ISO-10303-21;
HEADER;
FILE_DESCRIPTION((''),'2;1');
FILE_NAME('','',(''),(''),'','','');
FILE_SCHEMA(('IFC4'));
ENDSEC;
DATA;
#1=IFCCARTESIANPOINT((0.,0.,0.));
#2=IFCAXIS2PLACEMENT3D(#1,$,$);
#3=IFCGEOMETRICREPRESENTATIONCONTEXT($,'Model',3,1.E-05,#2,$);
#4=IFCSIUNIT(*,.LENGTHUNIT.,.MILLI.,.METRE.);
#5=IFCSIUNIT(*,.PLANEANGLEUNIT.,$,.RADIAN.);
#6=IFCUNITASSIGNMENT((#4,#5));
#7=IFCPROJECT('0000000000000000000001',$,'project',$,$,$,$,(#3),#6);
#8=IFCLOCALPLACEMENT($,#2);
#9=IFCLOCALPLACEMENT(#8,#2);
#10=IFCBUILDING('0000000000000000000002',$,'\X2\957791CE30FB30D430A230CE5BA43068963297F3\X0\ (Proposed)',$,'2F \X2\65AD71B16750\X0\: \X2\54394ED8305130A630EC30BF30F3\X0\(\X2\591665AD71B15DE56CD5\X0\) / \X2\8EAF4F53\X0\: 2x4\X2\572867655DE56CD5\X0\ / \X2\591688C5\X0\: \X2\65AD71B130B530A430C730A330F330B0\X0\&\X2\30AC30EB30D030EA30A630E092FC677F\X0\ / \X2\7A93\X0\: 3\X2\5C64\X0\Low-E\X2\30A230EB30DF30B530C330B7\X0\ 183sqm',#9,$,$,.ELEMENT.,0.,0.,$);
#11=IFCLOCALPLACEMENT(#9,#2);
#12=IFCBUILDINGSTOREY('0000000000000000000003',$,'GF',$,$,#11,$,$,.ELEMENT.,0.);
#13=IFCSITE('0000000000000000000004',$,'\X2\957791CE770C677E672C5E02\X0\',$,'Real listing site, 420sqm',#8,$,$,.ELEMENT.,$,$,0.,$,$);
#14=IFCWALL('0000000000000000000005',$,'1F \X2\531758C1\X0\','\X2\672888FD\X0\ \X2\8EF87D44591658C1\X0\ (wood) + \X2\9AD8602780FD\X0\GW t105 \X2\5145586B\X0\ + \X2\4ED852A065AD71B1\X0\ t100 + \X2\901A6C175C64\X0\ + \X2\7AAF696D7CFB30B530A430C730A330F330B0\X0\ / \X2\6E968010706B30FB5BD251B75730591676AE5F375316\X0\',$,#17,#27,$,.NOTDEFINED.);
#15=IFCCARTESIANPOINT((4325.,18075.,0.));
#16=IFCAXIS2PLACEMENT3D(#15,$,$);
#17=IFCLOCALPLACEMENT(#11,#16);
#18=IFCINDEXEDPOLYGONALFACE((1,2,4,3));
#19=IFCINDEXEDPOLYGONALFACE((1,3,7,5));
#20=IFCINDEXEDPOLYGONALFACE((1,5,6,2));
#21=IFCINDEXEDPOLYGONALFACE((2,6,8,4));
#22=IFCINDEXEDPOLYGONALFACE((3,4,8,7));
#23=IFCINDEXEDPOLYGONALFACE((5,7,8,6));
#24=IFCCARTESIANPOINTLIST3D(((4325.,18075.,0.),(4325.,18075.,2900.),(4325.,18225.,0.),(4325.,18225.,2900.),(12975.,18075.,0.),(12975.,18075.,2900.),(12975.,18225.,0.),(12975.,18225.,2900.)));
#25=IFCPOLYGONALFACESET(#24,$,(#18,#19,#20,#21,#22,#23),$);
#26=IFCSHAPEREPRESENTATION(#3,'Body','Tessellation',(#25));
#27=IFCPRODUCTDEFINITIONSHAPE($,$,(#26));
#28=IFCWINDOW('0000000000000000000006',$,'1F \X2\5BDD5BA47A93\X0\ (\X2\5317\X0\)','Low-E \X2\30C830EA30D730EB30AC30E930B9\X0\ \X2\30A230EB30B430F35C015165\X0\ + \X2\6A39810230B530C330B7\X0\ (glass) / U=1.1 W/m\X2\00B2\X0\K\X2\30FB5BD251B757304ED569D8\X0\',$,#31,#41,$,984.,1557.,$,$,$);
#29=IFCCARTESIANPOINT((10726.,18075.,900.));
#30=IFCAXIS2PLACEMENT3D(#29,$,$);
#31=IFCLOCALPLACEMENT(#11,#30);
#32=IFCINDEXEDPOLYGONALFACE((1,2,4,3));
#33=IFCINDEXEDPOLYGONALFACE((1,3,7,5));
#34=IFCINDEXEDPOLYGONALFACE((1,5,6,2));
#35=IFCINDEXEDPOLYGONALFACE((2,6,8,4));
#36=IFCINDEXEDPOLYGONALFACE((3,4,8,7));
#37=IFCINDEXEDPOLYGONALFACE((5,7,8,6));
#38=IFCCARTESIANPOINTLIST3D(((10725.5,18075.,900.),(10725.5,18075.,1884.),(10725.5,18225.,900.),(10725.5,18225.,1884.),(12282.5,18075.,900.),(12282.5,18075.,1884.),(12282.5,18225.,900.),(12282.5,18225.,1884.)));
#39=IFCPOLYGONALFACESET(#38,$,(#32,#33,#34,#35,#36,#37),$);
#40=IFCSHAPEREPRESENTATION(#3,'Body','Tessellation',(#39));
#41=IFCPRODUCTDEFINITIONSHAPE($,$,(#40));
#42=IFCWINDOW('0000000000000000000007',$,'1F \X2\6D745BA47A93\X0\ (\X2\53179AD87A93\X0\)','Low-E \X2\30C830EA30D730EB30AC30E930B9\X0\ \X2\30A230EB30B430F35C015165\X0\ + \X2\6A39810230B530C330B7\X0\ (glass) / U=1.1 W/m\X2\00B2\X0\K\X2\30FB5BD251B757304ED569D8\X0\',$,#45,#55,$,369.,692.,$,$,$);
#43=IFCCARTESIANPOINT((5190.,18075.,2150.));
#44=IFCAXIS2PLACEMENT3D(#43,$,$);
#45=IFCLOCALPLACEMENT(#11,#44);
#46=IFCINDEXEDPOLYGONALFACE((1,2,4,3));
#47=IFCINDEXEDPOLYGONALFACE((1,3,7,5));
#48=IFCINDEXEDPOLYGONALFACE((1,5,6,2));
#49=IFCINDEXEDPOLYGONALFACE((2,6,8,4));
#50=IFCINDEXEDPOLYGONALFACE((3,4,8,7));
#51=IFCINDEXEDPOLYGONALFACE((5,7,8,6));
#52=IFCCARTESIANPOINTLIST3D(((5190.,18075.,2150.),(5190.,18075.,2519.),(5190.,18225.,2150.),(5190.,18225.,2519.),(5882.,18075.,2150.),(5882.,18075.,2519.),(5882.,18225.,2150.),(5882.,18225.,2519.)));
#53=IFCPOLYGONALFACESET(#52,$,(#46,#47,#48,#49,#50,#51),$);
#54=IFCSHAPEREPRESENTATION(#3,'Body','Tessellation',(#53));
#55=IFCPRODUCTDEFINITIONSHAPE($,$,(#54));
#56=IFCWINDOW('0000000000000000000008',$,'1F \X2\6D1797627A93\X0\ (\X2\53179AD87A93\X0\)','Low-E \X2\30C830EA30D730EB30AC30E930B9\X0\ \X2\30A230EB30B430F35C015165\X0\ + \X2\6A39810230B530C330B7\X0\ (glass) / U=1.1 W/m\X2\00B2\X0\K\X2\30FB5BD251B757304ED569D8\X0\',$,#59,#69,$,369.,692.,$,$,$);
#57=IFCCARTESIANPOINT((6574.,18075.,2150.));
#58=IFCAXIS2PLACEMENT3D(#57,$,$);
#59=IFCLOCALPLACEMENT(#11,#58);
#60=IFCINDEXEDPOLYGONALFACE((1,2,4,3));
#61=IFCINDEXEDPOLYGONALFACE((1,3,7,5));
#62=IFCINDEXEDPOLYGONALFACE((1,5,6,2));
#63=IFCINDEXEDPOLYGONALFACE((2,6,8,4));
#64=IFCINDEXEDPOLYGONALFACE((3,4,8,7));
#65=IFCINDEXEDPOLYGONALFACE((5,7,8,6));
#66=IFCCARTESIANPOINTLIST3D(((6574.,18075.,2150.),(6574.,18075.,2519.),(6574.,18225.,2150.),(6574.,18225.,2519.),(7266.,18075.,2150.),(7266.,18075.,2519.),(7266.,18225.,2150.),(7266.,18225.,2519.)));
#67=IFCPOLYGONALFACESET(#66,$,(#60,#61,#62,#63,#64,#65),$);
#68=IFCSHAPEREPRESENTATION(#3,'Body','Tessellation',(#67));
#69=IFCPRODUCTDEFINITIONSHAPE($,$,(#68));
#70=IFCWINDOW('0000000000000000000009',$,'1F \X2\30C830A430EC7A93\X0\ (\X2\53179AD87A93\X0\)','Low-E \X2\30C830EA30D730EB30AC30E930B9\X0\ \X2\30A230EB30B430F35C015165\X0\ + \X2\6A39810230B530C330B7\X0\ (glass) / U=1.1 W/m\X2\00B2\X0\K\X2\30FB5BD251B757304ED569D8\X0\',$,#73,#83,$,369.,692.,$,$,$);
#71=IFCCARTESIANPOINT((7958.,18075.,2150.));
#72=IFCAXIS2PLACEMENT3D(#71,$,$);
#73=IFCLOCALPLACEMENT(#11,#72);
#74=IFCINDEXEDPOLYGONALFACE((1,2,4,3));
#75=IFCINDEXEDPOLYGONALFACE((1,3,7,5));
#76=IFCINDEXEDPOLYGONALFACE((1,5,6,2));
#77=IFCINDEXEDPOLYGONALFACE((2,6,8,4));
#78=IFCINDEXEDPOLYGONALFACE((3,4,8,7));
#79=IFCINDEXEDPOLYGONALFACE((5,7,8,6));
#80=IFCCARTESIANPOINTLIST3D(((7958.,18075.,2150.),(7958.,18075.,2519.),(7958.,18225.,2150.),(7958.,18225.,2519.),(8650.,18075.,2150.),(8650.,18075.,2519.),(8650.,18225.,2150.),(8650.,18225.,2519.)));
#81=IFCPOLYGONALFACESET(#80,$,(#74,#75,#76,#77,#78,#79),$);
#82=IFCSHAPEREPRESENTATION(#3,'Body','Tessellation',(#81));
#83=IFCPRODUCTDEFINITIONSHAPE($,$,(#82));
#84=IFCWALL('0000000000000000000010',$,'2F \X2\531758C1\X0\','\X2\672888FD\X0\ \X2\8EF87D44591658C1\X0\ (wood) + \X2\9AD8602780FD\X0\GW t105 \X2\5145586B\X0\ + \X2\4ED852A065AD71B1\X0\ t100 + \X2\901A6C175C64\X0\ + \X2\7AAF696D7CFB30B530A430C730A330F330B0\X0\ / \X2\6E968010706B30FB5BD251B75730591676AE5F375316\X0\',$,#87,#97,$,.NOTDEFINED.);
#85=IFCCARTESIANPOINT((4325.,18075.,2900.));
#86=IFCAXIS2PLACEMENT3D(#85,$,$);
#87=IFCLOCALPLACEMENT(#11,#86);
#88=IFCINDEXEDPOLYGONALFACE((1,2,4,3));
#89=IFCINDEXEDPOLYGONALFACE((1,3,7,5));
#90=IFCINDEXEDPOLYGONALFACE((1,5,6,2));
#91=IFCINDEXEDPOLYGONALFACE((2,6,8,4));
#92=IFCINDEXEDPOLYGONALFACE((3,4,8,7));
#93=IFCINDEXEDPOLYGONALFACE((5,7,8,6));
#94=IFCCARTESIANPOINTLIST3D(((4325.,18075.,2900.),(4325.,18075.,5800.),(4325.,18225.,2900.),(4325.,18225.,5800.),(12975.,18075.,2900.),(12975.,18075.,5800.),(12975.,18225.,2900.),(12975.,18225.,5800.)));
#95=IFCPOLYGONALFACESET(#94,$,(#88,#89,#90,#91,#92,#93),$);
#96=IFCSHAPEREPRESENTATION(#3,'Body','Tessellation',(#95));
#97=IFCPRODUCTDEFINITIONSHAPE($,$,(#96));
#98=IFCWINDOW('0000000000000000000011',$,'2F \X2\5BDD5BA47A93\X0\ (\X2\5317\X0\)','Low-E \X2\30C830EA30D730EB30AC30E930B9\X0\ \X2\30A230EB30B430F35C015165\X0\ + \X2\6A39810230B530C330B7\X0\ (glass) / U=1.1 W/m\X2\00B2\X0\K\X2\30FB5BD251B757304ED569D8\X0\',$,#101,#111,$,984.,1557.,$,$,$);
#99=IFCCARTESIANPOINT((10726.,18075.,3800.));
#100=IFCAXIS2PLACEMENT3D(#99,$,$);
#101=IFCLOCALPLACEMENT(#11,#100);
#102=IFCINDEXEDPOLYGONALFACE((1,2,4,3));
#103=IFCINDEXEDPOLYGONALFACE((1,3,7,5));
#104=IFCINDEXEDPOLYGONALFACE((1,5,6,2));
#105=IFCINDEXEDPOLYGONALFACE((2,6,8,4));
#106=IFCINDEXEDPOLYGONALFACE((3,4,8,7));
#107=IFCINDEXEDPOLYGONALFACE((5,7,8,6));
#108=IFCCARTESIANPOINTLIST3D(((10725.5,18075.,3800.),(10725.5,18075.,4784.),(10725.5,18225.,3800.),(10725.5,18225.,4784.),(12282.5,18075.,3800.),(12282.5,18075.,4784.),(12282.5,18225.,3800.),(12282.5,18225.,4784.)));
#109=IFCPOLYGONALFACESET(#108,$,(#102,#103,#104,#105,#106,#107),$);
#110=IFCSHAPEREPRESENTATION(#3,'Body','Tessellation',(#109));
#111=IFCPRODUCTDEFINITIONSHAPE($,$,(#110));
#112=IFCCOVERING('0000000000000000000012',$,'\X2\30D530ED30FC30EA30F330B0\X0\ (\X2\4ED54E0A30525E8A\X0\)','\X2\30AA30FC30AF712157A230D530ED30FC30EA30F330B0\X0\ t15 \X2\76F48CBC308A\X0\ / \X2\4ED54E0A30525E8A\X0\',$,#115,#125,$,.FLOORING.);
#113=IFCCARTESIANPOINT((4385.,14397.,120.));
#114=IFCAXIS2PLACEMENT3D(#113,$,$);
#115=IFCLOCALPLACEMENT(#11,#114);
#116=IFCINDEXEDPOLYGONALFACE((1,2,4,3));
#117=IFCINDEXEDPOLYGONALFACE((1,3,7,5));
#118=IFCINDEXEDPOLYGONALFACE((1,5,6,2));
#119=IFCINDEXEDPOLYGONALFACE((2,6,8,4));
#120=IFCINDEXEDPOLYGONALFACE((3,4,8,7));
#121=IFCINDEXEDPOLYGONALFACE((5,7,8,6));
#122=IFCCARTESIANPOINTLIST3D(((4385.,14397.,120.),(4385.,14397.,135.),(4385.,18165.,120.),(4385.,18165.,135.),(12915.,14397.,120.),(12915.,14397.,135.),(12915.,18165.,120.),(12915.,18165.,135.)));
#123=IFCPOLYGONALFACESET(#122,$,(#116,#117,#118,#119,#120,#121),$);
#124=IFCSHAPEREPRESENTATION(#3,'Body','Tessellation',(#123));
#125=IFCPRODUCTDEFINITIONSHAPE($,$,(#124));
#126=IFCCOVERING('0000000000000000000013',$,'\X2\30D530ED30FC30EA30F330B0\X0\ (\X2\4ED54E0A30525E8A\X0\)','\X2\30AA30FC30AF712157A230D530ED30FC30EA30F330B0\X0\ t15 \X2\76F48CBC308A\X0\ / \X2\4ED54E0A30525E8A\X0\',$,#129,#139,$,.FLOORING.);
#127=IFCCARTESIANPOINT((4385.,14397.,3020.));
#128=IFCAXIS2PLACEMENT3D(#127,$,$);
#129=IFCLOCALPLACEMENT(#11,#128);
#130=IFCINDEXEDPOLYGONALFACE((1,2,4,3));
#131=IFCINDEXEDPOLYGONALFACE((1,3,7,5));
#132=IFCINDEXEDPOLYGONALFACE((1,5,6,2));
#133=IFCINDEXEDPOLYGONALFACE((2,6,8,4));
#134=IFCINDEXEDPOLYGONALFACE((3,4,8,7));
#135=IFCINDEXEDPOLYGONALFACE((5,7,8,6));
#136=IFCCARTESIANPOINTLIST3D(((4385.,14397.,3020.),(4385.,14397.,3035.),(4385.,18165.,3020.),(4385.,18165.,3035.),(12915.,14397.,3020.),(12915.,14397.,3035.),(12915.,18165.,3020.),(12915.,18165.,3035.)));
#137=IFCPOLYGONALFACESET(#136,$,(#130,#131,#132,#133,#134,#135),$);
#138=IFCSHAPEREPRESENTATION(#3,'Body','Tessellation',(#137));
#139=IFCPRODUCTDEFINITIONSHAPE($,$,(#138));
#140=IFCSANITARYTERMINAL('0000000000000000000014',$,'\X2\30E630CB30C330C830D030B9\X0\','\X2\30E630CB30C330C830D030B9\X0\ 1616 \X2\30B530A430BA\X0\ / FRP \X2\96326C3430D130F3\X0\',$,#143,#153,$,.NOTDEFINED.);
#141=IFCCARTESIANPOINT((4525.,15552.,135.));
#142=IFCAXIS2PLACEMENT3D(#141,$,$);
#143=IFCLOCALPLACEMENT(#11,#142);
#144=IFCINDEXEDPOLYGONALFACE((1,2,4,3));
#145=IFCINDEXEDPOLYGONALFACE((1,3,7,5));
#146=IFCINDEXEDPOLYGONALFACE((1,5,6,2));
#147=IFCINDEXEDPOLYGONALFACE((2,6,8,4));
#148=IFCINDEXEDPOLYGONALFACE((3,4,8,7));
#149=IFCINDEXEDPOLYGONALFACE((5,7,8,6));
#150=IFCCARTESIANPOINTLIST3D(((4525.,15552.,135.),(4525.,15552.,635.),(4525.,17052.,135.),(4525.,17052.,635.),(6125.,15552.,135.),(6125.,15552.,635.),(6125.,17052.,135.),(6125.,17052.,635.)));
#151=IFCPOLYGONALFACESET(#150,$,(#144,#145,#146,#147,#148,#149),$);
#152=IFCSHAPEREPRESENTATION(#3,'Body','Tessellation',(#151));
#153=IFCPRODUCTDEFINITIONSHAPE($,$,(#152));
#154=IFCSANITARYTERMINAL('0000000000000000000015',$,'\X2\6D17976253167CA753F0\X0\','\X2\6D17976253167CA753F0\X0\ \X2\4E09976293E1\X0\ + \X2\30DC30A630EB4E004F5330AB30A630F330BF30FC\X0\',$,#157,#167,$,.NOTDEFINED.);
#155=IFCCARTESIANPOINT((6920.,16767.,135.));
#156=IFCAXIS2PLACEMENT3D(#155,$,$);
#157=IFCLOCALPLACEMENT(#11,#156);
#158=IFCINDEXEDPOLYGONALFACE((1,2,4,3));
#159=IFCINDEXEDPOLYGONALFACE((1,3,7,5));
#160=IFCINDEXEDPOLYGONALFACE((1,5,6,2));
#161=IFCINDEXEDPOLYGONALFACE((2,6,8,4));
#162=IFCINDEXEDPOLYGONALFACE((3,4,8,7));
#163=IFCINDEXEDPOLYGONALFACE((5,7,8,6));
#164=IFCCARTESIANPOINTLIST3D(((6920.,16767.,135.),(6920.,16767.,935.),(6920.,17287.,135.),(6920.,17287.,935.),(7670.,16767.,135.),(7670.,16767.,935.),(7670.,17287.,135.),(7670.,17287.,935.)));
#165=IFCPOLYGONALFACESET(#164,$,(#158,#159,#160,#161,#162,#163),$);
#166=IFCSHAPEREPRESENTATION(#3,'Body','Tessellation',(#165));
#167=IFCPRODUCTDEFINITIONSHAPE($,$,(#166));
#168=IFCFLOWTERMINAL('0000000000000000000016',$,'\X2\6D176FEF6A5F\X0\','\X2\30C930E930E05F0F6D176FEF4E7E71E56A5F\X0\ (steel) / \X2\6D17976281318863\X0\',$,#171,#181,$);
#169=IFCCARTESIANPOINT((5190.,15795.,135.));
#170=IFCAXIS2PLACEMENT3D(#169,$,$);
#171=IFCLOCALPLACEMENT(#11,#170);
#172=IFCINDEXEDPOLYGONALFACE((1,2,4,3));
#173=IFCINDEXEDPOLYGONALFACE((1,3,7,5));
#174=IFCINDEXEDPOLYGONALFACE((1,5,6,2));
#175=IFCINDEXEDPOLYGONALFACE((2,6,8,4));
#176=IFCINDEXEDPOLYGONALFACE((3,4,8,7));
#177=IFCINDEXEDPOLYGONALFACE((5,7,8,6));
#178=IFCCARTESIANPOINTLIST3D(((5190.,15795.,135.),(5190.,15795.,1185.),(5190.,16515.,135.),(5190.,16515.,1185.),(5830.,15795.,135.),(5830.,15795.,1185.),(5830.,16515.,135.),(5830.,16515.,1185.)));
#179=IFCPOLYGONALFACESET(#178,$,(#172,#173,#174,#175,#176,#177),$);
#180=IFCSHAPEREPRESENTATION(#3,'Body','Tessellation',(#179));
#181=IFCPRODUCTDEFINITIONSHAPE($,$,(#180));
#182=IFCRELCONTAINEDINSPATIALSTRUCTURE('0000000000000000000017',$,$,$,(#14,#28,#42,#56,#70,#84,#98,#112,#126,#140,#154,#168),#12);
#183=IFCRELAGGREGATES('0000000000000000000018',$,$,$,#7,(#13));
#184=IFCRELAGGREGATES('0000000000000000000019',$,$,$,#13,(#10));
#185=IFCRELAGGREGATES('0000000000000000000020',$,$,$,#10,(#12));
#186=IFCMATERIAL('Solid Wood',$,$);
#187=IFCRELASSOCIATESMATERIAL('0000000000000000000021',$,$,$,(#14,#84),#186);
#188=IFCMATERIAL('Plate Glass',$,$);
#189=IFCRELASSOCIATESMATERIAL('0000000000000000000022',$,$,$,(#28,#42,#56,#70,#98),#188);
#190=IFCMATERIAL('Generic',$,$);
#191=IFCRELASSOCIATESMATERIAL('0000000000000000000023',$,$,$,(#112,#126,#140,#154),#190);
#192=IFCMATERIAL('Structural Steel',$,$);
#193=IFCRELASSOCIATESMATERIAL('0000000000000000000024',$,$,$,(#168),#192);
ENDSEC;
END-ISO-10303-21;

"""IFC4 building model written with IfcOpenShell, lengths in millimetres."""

from ifc_helpers import new_model, si_unit, frame, frame_2d, origin, place, context, project, spatial, rectangle, extrude, material, element, fill, save


model = new_model("IFC4")

# Units and contexts
model_context = context("Model", 3, precision=1e-05, world=origin())
ifc_project = project(units=[si_unit("LENGTHUNIT", "METRE", prefix="MILLI"), si_unit("PLANEANGLEUNIT", "RADIAN")], contexts=[model_context])

# Site, building, storey
site_placement = place(None, origin())
site = spatial("IfcSite", under=ifc_project, at=site_placement, Name="長野県松本市", ObjectType="Real listing site, 420sqm", CompositionType="ELEMENT", RefElevation=0.0)
building_placement = place(site_placement, origin())
building = spatial("IfcBuilding", under=site, at=building_placement, Name="長野・ピアノ室と防音 (Proposed)", ObjectType="2F 断熱材: 吹付けウレタン(外断熱工法) / 躯体: 2x4在来工法 / 外装: 断熱サイディング&ガルバリウム鋼板 / 窓: 3層Low-Eアルミサッシ 183sqm", CompositionType="ELEMENT", ElevationOfRefHeight=0.0, ElevationOfTerrain=0.0)
storey_placement = place(building_placement, origin())
storey = spatial("IfcBuildingStorey", under=building, at=storey_placement, Name="GF", CompositionType="ELEMENT", Elevation=0.0)

# Shared definitions
ifc_material_1 = material(Name="Solid Wood")

# Wall, openings, windows
wall_1_placement = place(storey_placement, frame((4325.0, 18075.0, 0.0)))
wall_1 = element("IfcWall", 1, at=wall_1_placement, inside=storey, material=ifc_material_1, Name="1F 北壁", Description="木製 軸組外壁 (wood) + 高性能GW t105 充填 + 付加断熱 t100 + 通気層 + 窯業系サイディング / 準耐火・寒冷地外皮強化", PredefinedType="NOTDEFINED", context=model_context, shape_type="SweptSolid", body=[
    extrude(rectangle(XDim=8650.0, YDim=150.0, at=frame_2d((4325.0, 75.0))), frame((4325.0, 18075.0, 0.0)), (0.0, 0.0, 1.0), 2900.0),
])
opening_1_placement = place(storey_placement, frame((10726.0, 18075.0, 900.0)))
opening_1 = element("IfcOpeningElement", 2, at=opening_1_placement, cuts=wall_1, PredefinedType="NOTDEFINED", context=model_context, shape_type="SweptSolid", body=[
    extrude(rectangle(XDim=1557.0, YDim=150.0, at=frame_2d((778.0, 75.0))), frame((10726.0, 18075.0, 900.0)), (0.0, 0.0, 1.0), 984.0),
])
opening_2_placement = place(storey_placement, frame((5190.0, 18075.0, 2150.0)))
opening_2 = element("IfcOpeningElement", 3, at=opening_2_placement, cuts=wall_1, PredefinedType="NOTDEFINED", context=model_context, shape_type="SweptSolid", body=[
    extrude(rectangle(XDim=692.0, YDim=150.0, at=frame_2d((346.0, 75.0))), frame((5190.0, 18075.0, 2150.0)), (0.0, 0.0, 1.0), 369.0),
])
opening_3_placement = place(storey_placement, frame((6574.0, 18075.0, 2150.0)))
opening_3 = element("IfcOpeningElement", 4, at=opening_3_placement, cuts=wall_1, PredefinedType="NOTDEFINED", context=model_context, shape_type="SweptSolid", body=[
    extrude(rectangle(XDim=692.0, YDim=150.0, at=frame_2d((346.0, 75.0))), frame((6574.0, 18075.0, 2150.0)), (0.0, 0.0, 1.0), 369.0),
])
opening_4_placement = place(storey_placement, frame((7958.0, 18075.0, 2150.0)))
opening_4 = element("IfcOpeningElement", 5, at=opening_4_placement, cuts=wall_1, PredefinedType="NOTDEFINED", context=model_context, shape_type="SweptSolid", body=[
    extrude(rectangle(XDim=692.0, YDim=150.0, at=frame_2d((346.0, 75.0))), frame((7958.0, 18075.0, 2150.0)), (0.0, 0.0, 1.0), 369.0),
])
ifc_material_2 = material(Name="Plate Glass")
window_1_placement = place(storey_placement, frame((10726.0, 18075.0, 900.0)))
window_1 = element("IfcWindow", 6, at=window_1_placement, inside=storey, material=ifc_material_2, Name="1F 寝室窓 (北)", Description="Low-E トリプルガラス アルゴン封入 + 樹脂サッシ (glass) / U=1.1 W/m²K・寒冷地仕様", OverallHeight=984.0, OverallWidth=1557.0, context=model_context, shape_type="SweptSolid", body=[
    extrude(rectangle(XDim=1557.0, YDim=150.0, at=frame_2d((778.0, 75.0))), frame((10726.0, 18075.0, 900.0)), (0.0, 0.0, 1.0), 984.0),
])
fill(opening_1, window_1)
window_2_placement = place(storey_placement, frame((5190.0, 18075.0, 2150.0)))
window_2 = element("IfcWindow", 7, at=window_2_placement, inside=storey, material=ifc_material_2, Name="1F 浴室窓 (北高窓)", Description="Low-E トリプルガラス アルゴン封入 + 樹脂サッシ (glass) / U=1.1 W/m²K・寒冷地仕様", OverallHeight=369.0, OverallWidth=692.0, context=model_context, shape_type="SweptSolid", body=[
    extrude(rectangle(XDim=692.0, YDim=150.0, at=frame_2d((346.0, 75.0))), frame((5190.0, 18075.0, 2150.0)), (0.0, 0.0, 1.0), 369.0),
])
fill(opening_2, window_2)
window_3_placement = place(storey_placement, frame((6574.0, 18075.0, 2150.0)))
window_3 = element("IfcWindow", 8, at=window_3_placement, inside=storey, material=ifc_material_2, Name="1F 洗面窓 (北高窓)", Description="Low-E トリプルガラス アルゴン封入 + 樹脂サッシ (glass) / U=1.1 W/m²K・寒冷地仕様", OverallHeight=369.0, OverallWidth=692.0, context=model_context, shape_type="SweptSolid", body=[
    extrude(rectangle(XDim=692.0, YDim=150.0, at=frame_2d((346.0, 75.0))), frame((6574.0, 18075.0, 2150.0)), (0.0, 0.0, 1.0), 369.0),
])
fill(opening_3, window_3)
window_4_placement = place(storey_placement, frame((7958.0, 18075.0, 2150.0)))
window_4 = element("IfcWindow", 9, at=window_4_placement, inside=storey, material=ifc_material_2, Name="1F トイレ窓 (北高窓)", Description="Low-E トリプルガラス アルゴン封入 + 樹脂サッシ (glass) / U=1.1 W/m²K・寒冷地仕様", OverallHeight=369.0, OverallWidth=692.0, context=model_context, shape_type="SweptSolid", body=[
    extrude(rectangle(XDim=692.0, YDim=150.0, at=frame_2d((346.0, 75.0))), frame((7958.0, 18075.0, 2150.0)), (0.0, 0.0, 1.0), 369.0),
])
fill(opening_4, window_4)

# Wall, opening, window
wall_2_placement = place(storey_placement, frame((4325.0, 18075.0, 2900.0)))
wall_2 = element("IfcWall", 10, at=wall_2_placement, inside=storey, material=ifc_material_1, Name="2F 北壁", Description="木製 軸組外壁 (wood) + 高性能GW t105 充填 + 付加断熱 t100 + 通気層 + 窯業系サイディング / 準耐火・寒冷地外皮強化", PredefinedType="NOTDEFINED", context=model_context, shape_type="SweptSolid", body=[
    extrude(rectangle(XDim=8650.0, YDim=150.0, at=frame_2d((4325.0, 75.0))), frame((4325.0, 18075.0, 2900.0)), (0.0, 0.0, 1.0), 2900.0),
])
opening_5_placement = place(storey_placement, frame((10726.0, 18075.0, 3800.0)))
opening_5 = element("IfcOpeningElement", 11, at=opening_5_placement, cuts=wall_2, PredefinedType="NOTDEFINED", context=model_context, shape_type="SweptSolid", body=[
    extrude(rectangle(XDim=1557.0, YDim=150.0, at=frame_2d((778.0, 75.0))), frame((10726.0, 18075.0, 3800.0)), (0.0, 0.0, 1.0), 984.0),
])
window_5_placement = place(storey_placement, frame((10726.0, 18075.0, 3800.0)))
window_5 = element("IfcWindow", 12, at=window_5_placement, inside=storey, material=ifc_material_2, Name="2F 寝室窓 (北)", Description="Low-E トリプルガラス アルゴン封入 + 樹脂サッシ (glass) / U=1.1 W/m²K・寒冷地仕様", OverallHeight=984.0, OverallWidth=1557.0, context=model_context, shape_type="SweptSolid", body=[
    extrude(rectangle(XDim=1557.0, YDim=150.0, at=frame_2d((778.0, 75.0))), frame((10726.0, 18075.0, 3800.0)), (0.0, 0.0, 1.0), 984.0),
])
fill(opening_5, window_5)

# Coverings
ifc_material_3 = material(Name="Generic")
covering_1_placement = place(storey_placement, frame((4385.0, 14397.0, 120.0)))
element("IfcCovering", 13, at=covering_1_placement, inside=storey, material=ifc_material_3, Name="フローリング (仕上げ床)", Description="オーク無垢フローリング t15 直貼り / 仕上げ床", PredefinedType="FLOORING", context=model_context, shape_type="SweptSolid", body=[
    extrude(rectangle(XDim=8530.0, YDim=3768.0, at=frame_2d((4265.0, 1884.0))), frame((4385.0, 14397.0, 120.0)), (0.0, 0.0, 1.0), 15.0),
])
covering_2_placement = place(storey_placement, frame((4385.0, 14397.0, 3020.0)))
element("IfcCovering", 14, at=covering_2_placement, inside=storey, material=ifc_material_3, Name="フローリング (仕上げ床)", Description="オーク無垢フローリング t15 直貼り / 仕上げ床", PredefinedType="FLOORING", context=model_context, shape_type="SweptSolid", body=[
    extrude(rectangle(XDim=8530.0, YDim=3768.0, at=frame_2d((4265.0, 1884.0))), frame((4385.0, 14397.0, 3020.0)), (0.0, 0.0, 1.0), 15.0),
])

# Sanitary terminals
sanitary_terminal_1_placement = place(storey_placement, frame((4525.0, 15552.0, 135.0)))
element("IfcSanitaryTerminal", 15, at=sanitary_terminal_1_placement, inside=storey, material=ifc_material_3, Name="ユニットバス", Description="ユニットバス 1616 サイズ / FRP 防水パン", PredefinedType="NOTDEFINED", context=model_context, shape_type="SweptSolid", body=[
    extrude(rectangle(XDim=1600.0, YDim=1500.0, at=frame_2d((800.0, 750.0))), frame((4525.0, 15552.0, 135.0)), (0.0, 0.0, 1.0), 500.0),
])
sanitary_terminal_2_placement = place(storey_placement, frame((6920.0, 16767.0, 135.0)))
element("IfcSanitaryTerminal", 16, at=sanitary_terminal_2_placement, inside=storey, material=ifc_material_3, Name="洗面化粧台", Description="洗面化粧台 三面鏡 + ボウル一体カウンター", PredefinedType="NOTDEFINED", context=model_context, shape_type="SweptSolid", body=[
    extrude(rectangle(XDim=750.0, YDim=520.0, at=frame_2d((375.0, 260.0))), frame((6920.0, 16767.0, 135.0)), (0.0, 0.0, 1.0), 800.0),
])

# Flow terminal
ifc_material_4 = material(Name="Structural Steel")
flow_terminal_placement = place(storey_placement, frame((5190.0, 15795.0, 135.0)))
element("IfcFlowTerminal", 17, at=flow_terminal_placement, inside=storey, material=ifc_material_4, Name="洗濯機", Description="ドラム式洗濯乾燥機 (steel) / 洗面脱衣", context=model_context, shape_type="SweptSolid", body=[
    extrude(rectangle(XDim=640.0, YDim=720.0, at=frame_2d((320.0, 360.0))), frame((5190.0, 15795.0, 135.0)), (0.0, 0.0, 1.0), 1050.0),
])

save(model, "model.ifc")
